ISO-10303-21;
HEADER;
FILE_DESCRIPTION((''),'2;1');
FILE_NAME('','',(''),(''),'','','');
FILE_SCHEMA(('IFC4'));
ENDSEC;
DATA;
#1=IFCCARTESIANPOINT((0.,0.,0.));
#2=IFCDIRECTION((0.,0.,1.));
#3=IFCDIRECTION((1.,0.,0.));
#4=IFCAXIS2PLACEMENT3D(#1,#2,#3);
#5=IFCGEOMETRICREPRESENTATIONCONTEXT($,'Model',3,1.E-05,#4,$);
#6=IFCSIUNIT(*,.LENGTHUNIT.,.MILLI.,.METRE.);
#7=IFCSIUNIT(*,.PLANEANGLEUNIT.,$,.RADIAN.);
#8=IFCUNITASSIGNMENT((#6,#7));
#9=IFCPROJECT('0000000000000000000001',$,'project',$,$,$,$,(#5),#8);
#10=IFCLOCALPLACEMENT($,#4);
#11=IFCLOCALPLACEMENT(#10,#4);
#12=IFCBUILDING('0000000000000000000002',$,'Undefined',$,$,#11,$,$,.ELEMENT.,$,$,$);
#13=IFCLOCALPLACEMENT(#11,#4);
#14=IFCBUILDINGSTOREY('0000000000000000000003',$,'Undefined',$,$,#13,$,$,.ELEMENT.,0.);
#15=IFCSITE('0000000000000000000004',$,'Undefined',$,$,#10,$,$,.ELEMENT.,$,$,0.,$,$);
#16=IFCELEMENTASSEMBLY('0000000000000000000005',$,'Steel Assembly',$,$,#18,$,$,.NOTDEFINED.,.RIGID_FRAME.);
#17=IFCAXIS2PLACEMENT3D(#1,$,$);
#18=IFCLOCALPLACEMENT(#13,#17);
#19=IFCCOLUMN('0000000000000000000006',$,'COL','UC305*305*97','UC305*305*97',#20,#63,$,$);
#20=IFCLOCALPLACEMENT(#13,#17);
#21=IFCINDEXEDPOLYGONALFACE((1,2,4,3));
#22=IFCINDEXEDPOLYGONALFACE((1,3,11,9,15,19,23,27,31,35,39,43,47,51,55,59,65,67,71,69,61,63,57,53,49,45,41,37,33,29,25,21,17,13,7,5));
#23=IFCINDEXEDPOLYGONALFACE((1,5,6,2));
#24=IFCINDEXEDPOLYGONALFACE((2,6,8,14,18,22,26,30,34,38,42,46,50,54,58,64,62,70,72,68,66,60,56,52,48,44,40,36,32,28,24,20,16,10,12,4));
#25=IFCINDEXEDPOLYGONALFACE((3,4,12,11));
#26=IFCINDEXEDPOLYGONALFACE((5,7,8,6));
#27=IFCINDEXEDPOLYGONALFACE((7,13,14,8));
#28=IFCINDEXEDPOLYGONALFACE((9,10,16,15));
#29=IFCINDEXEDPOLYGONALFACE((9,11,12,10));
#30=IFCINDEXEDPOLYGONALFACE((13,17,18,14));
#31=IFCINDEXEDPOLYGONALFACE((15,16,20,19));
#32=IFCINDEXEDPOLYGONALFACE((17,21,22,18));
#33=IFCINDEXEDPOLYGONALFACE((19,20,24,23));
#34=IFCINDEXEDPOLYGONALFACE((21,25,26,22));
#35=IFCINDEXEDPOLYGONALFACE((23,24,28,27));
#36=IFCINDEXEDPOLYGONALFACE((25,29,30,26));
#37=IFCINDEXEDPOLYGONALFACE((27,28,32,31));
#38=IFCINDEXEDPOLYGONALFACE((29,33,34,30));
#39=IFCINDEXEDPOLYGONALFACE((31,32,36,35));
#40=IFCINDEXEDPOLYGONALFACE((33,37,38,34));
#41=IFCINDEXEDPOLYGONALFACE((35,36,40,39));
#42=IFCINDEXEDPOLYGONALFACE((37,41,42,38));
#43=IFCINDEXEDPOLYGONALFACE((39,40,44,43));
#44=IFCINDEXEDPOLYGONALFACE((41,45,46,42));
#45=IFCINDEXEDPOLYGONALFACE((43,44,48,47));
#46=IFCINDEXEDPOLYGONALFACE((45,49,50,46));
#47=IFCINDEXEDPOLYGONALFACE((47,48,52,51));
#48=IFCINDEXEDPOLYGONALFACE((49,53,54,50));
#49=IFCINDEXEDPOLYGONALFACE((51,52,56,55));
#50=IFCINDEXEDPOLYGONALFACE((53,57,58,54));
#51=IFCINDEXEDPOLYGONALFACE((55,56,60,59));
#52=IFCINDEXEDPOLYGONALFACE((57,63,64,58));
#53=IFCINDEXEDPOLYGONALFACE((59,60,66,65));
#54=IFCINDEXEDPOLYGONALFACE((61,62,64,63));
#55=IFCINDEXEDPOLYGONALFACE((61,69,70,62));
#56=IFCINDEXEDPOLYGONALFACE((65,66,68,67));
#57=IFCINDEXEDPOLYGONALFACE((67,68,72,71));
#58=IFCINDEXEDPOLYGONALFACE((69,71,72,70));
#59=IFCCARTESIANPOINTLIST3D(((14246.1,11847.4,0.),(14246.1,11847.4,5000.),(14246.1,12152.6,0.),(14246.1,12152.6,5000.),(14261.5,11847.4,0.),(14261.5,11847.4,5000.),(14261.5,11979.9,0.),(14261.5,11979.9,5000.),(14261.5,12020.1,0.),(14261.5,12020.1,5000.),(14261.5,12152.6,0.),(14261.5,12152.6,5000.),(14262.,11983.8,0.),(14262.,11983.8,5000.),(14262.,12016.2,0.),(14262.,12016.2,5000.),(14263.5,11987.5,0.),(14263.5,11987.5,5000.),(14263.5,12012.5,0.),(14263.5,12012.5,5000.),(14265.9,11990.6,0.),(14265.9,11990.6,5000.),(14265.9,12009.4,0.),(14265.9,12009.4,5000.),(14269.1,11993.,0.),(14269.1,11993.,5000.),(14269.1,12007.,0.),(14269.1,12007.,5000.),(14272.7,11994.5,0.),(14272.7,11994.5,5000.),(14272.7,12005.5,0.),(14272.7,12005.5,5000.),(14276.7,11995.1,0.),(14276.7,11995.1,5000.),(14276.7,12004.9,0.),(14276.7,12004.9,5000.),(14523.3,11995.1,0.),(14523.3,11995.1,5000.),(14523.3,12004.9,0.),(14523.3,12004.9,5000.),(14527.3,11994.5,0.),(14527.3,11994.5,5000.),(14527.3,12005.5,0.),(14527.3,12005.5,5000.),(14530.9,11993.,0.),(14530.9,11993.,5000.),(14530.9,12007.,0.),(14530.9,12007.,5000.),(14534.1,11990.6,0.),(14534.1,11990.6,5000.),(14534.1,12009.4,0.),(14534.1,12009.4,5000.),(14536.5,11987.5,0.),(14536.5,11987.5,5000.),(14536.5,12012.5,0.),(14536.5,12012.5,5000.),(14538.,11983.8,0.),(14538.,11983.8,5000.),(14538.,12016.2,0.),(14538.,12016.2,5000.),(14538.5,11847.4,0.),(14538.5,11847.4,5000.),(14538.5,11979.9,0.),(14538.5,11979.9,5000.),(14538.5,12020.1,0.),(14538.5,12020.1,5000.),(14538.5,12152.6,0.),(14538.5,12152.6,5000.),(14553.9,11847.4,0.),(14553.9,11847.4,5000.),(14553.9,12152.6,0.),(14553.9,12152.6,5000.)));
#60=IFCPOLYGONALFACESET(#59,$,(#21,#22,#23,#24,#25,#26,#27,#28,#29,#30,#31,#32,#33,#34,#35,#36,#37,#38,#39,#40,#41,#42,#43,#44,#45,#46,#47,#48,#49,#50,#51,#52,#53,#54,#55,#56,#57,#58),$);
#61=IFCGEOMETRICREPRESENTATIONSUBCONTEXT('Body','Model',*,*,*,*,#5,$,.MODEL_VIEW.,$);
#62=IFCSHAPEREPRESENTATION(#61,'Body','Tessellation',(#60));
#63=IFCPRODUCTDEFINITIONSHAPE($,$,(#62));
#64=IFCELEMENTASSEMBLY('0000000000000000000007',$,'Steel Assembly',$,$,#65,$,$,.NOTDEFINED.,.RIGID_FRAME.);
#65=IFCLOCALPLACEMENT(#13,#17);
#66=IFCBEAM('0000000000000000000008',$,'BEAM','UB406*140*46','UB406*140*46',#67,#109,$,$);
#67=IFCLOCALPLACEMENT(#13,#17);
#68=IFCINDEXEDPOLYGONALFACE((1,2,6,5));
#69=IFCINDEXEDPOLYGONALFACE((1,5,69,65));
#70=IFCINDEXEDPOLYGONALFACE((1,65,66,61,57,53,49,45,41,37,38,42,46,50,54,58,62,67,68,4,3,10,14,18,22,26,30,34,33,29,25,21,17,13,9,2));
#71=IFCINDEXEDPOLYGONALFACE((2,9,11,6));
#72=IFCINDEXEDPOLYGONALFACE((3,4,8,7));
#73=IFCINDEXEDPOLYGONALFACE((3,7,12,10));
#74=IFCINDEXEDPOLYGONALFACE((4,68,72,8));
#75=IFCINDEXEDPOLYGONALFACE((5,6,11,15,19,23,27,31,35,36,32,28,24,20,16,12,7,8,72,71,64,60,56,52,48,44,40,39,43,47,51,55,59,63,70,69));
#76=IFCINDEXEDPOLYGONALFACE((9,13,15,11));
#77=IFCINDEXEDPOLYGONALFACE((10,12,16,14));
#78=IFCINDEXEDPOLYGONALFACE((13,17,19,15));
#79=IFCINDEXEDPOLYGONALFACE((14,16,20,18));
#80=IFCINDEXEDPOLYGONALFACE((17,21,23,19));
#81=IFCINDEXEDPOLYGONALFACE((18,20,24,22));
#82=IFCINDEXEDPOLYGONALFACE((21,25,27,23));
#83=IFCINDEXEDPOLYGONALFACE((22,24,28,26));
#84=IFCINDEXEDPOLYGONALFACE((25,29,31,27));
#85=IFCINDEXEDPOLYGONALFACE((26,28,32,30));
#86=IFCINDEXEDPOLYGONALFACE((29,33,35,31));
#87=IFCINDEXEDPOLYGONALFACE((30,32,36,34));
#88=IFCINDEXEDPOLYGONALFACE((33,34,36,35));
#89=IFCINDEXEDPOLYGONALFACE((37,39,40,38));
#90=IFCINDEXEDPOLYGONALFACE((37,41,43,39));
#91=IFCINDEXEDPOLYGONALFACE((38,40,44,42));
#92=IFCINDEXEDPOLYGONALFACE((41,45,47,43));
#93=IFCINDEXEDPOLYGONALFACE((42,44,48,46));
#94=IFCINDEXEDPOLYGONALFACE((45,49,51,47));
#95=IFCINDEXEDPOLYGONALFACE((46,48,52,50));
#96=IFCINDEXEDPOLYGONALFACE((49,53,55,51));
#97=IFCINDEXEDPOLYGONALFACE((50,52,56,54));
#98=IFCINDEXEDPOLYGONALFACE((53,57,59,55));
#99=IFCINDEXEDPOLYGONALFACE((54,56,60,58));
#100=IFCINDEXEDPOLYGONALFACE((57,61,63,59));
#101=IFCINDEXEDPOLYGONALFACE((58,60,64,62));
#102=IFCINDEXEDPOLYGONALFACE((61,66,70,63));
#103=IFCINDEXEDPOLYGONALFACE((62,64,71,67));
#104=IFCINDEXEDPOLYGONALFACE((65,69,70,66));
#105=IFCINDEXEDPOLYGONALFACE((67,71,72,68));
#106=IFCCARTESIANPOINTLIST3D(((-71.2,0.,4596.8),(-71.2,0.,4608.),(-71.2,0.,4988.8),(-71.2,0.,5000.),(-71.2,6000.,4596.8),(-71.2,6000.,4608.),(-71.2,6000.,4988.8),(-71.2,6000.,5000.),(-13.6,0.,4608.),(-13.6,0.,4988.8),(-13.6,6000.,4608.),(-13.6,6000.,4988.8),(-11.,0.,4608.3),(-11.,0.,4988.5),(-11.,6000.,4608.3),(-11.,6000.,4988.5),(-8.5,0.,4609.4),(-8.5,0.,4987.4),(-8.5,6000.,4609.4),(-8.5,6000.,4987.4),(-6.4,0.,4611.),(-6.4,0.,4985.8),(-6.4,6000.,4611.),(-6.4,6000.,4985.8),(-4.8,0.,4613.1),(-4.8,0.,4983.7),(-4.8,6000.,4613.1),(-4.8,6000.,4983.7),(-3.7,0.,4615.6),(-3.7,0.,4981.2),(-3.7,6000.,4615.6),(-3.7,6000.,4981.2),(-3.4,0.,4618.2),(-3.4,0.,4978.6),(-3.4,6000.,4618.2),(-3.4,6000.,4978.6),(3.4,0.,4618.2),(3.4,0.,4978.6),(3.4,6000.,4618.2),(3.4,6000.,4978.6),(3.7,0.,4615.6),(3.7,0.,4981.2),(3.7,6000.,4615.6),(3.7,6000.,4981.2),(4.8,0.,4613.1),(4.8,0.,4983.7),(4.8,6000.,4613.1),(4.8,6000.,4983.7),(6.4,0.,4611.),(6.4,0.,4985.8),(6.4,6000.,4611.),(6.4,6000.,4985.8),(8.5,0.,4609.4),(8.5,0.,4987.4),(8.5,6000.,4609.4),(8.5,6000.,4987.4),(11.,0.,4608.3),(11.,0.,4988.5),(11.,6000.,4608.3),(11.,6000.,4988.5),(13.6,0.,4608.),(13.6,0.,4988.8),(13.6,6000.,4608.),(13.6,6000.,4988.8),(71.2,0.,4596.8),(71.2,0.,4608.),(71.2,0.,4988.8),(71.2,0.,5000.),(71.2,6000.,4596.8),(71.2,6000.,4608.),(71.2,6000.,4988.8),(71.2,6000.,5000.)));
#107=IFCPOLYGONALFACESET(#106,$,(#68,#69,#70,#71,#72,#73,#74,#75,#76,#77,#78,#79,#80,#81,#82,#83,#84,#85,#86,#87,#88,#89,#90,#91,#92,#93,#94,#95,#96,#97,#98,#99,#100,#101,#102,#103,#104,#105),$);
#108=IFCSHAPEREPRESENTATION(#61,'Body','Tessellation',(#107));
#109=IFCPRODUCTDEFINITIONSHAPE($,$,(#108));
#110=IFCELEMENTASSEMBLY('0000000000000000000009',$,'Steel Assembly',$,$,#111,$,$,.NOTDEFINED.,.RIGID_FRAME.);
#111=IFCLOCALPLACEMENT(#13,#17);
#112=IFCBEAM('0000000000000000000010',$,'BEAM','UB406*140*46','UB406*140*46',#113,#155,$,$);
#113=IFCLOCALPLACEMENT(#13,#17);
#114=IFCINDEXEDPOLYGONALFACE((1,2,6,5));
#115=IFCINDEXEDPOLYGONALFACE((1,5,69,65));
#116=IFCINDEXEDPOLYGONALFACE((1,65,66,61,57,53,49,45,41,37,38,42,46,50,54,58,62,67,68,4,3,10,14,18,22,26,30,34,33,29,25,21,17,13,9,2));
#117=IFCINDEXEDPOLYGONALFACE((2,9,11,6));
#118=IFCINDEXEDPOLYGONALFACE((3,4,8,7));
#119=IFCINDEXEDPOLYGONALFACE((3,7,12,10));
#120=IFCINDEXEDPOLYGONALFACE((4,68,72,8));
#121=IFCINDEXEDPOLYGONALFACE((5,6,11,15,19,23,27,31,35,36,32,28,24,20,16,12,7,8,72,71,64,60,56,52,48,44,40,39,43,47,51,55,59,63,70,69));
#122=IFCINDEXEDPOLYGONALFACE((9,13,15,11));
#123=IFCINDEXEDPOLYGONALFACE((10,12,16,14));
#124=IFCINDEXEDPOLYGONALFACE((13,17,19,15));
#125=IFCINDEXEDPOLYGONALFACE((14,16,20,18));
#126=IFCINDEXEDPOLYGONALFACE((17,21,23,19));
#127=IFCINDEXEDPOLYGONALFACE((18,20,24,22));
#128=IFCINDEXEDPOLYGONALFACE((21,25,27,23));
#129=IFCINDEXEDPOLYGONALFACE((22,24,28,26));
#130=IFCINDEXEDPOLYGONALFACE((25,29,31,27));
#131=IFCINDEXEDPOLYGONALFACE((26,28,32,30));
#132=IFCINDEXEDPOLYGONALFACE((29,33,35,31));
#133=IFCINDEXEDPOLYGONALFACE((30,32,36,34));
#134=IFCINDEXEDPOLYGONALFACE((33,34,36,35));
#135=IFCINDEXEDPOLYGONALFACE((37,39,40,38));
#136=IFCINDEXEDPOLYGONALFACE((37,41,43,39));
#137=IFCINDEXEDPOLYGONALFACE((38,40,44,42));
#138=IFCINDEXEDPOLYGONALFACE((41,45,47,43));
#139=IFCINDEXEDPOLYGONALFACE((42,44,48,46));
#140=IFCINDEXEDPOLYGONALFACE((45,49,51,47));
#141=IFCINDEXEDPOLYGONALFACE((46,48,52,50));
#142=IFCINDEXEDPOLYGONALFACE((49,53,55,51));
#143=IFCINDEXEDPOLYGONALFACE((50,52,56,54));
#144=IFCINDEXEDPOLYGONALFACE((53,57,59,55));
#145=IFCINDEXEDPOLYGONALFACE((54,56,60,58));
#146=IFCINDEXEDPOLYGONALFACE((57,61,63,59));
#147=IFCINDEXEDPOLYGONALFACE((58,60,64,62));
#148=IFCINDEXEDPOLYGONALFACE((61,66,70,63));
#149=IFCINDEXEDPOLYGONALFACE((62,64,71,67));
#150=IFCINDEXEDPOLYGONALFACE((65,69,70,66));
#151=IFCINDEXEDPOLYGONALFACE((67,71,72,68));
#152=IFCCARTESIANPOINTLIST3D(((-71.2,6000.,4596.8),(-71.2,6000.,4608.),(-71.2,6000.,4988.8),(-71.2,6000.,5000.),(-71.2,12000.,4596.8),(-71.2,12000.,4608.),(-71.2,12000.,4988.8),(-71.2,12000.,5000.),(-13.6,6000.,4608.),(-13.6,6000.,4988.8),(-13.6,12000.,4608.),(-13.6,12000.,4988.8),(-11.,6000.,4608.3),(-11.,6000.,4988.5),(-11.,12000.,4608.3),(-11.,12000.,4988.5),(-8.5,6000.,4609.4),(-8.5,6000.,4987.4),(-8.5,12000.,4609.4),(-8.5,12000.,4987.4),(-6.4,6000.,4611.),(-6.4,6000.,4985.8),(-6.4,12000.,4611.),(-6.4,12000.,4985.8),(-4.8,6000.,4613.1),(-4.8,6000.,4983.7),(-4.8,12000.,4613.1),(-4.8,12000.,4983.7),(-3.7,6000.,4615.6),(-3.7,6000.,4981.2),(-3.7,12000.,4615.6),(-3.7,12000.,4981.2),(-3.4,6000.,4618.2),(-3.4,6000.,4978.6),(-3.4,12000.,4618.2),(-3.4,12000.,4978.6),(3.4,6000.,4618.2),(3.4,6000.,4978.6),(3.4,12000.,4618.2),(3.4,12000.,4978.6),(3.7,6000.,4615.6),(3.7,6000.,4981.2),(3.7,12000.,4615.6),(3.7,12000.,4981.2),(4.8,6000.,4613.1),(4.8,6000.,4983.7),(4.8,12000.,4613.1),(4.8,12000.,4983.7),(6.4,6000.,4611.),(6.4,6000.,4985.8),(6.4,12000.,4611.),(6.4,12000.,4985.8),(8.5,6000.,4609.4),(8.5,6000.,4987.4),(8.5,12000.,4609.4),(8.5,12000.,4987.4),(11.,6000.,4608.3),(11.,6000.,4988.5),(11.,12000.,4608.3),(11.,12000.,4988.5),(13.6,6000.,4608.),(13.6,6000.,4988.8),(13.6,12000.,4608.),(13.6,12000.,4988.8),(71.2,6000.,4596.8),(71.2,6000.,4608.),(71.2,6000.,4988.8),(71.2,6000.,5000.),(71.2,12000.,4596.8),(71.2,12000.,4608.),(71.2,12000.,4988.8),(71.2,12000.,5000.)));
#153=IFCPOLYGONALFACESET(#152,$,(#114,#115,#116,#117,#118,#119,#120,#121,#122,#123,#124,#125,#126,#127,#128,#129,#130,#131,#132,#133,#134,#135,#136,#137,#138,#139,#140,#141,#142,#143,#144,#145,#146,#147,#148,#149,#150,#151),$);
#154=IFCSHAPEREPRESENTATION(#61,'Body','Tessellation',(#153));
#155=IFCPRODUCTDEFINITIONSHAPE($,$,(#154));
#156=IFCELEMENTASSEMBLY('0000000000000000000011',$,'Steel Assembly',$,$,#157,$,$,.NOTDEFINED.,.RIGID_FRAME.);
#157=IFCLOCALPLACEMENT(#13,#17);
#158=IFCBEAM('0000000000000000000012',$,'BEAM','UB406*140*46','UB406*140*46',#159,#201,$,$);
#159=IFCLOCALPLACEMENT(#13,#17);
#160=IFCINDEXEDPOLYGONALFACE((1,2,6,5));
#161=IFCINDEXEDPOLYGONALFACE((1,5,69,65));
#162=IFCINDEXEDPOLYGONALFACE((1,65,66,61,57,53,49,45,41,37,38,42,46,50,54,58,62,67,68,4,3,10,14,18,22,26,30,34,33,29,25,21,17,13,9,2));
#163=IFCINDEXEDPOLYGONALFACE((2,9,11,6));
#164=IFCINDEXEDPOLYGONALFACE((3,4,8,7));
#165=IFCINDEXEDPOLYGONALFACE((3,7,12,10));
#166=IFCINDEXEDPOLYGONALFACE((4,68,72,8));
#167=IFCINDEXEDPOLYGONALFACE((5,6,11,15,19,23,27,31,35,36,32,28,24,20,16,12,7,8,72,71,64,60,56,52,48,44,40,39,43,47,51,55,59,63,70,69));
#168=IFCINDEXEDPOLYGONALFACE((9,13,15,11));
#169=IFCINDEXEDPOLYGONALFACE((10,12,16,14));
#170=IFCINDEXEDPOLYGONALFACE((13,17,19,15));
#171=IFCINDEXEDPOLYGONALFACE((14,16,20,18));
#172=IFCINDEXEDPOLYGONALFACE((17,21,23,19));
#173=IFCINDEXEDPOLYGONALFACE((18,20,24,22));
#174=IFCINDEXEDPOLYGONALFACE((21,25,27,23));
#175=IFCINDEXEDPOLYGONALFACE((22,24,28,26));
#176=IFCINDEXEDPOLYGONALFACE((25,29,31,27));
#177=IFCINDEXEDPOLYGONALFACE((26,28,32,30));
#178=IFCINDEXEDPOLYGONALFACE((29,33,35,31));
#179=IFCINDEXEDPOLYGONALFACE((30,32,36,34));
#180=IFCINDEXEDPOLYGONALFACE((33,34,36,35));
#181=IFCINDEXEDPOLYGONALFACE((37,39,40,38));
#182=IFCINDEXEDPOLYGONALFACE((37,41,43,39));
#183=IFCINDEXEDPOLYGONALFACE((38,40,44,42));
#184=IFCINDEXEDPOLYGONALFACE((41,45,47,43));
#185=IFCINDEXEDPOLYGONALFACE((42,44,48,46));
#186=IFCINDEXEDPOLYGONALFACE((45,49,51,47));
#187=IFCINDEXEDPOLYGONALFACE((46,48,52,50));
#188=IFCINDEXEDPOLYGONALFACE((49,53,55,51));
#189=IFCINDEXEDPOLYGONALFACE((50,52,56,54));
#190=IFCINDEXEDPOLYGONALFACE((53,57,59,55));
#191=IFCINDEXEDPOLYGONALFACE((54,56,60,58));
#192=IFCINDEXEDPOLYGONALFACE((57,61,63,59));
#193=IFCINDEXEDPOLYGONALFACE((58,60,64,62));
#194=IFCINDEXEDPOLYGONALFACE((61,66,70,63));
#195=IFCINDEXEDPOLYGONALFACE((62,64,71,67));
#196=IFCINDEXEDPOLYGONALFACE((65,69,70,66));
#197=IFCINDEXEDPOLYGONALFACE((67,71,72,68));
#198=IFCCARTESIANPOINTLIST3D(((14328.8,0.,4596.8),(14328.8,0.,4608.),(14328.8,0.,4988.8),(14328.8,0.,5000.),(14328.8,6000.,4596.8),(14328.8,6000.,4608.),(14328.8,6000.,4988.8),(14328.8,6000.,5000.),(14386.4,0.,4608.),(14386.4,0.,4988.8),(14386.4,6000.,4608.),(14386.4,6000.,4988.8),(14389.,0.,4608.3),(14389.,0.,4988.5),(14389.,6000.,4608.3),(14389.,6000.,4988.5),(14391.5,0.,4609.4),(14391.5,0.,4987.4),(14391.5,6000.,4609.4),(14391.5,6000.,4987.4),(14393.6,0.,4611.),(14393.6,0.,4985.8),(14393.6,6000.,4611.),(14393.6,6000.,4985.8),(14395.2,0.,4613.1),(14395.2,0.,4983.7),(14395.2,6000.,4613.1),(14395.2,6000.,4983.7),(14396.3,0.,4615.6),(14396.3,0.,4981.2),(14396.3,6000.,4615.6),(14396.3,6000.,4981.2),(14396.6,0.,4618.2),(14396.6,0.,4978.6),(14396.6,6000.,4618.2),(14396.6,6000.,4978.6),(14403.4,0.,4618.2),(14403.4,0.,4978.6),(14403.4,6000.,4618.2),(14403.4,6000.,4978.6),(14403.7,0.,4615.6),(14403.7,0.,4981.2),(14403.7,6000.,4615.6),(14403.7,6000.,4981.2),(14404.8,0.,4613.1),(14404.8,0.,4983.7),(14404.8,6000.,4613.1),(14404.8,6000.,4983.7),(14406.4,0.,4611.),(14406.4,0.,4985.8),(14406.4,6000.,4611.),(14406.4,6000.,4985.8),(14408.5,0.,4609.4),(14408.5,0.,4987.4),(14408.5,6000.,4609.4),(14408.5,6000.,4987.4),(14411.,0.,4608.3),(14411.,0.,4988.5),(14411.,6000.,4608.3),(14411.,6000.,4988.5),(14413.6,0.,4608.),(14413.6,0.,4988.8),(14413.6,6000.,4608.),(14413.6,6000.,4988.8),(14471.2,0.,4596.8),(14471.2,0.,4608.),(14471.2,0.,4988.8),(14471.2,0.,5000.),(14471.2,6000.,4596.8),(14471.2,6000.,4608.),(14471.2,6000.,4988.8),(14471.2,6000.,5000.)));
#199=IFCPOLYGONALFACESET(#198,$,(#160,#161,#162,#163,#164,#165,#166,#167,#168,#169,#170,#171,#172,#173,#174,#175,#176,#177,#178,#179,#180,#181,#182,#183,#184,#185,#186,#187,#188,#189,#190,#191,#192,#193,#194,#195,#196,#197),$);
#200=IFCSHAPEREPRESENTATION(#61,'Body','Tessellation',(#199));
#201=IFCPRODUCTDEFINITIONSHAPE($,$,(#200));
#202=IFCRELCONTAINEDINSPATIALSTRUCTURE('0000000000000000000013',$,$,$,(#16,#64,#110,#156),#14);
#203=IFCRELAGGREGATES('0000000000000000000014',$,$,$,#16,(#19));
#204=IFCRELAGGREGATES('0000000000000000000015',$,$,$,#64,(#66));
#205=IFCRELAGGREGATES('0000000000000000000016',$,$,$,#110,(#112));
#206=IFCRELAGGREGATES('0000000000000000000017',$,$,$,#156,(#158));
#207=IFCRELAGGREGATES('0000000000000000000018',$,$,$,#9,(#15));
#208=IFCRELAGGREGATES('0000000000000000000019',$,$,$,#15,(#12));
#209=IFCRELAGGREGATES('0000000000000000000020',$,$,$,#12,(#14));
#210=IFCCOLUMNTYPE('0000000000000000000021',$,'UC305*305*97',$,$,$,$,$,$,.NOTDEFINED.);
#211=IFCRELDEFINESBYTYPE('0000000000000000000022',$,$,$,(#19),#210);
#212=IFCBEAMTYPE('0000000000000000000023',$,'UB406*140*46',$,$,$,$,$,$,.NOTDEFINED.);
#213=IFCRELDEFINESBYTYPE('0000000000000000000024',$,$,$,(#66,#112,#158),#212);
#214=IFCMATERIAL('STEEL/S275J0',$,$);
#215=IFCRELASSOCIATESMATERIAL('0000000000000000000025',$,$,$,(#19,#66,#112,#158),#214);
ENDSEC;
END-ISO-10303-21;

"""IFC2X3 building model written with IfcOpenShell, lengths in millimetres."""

from ifc_helpers import new_model, si_unit, frame, origin_with_axes, origin_2d_with_axis, place, context, subcontext, project, spatial, i_section, extrude, material, type_object, element, aggregate, save


model = new_model("IFC2X3")

# Units and contexts
model_context = context("Model", 3, precision=1e-05, world=origin_with_axes())
body_context = subcontext(model_context, "Body", "Model", "MODEL_VIEW")
ifc_project = project(units=[si_unit("LENGTHUNIT", "METRE", prefix="MILLI"), si_unit("PLANEANGLEUNIT", "RADIAN")], contexts=[model_context])

# Site, building, storey
site_placement = place(None, origin_with_axes())
site = spatial("IfcSite", under=ifc_project, at=site_placement, Name="Undefined", CompositionType="ELEMENT", RefElevation=0.0)
building_placement = place(site_placement, origin_with_axes())
building = spatial("IfcBuilding", under=site, at=building_placement, Name="Undefined", CompositionType="ELEMENT")
storey_placement = place(building_placement, origin_with_axes())
storey = spatial("IfcBuildingStorey", under=building, at=storey_placement, Name="Undefined", CompositionType="ELEMENT", Elevation=0.0)

# Element assembly, column
ifc_material = material(Name="STEEL/S275J0")
column_type_1 = type_object("IfcColumnType", Name="UC305*305*97", PredefinedType="NOTDEFINED")
assembly_1_placement = place(storey_placement, origin_with_axes())
assembly_1 = element("IfcElementAssembly", 1, at=assembly_1_placement, inside=storey, Name="Steel Assembly", AssemblyPlace="NOTDEFINED", PredefinedType="RIGID_FRAME")
column_1_placement = place(assembly_1_placement, frame((14400.0, 12000.0, 0.0), z_axis=(0.0, 0.0, 1.0), x_axis=(1.0, 0.0, 0.0)))
column_1 = element("IfcColumn", 2, at=column_1_placement, type_object=column_type_1, material=ifc_material, Name="COL", Description="UC305*305*97", ObjectType="UC305*305*97", context=body_context, shape_type="SweptSolid", body=[
    extrude(i_section(OverallWidth=305.3, OverallDepth=307.9, WebThickness=9.9, FlangeThickness=15.4, FilletRadius=15.2, at=origin_2d_with_axis()), frame((0.0, 0.0, 5000.0), z_axis=(0.0, 0.0, -1.0), x_axis=(0.0, -1.0, 0.0)), (0.0, 0.0, 1.0), 5000.0),
])
aggregate(assembly_1, [column_1])

# Element assemblies, beams
assembly_2_placement = place(storey_placement, origin_with_axes())
assembly_2 = element("IfcElementAssembly", 3, at=assembly_2_placement, inside=storey, Name="Steel Assembly", AssemblyPlace="NOTDEFINED", PredefinedType="RIGID_FRAME")
beam_type_1 = type_object("IfcBeamType", Name="UB406*140*46", PredefinedType="NOTDEFINED")
beam_1_placement = place(assembly_2_placement, frame((0.0, 0.0, 4798.4), z_axis=(0.0, 0.0, 1.0), x_axis=(0.0, 1.0, 0.0)))
beam_1 = element("IfcBeam", 4, at=beam_1_placement, type_object=beam_type_1, material=ifc_material, Name="BEAM", Description="UB406*140*46", ObjectType="UB406*140*46", context=body_context, shape_type="SweptSolid", body=[
    extrude(i_section(OverallWidth=142.4, OverallDepth=403.2, WebThickness=6.8, FlangeThickness=11.2, FilletRadius=10.2, at=origin_2d_with_axis()), frame((6000.0, 0.0, 0.0), z_axis=(-1.0, 0.0, 0.0), x_axis=(0.0, -1.0, 0.0)), (0.0, 0.0, 1.0), 6000.0),
])
aggregate(assembly_2, [beam_1])
assembly_3_placement = place(storey_placement, origin_with_axes())
assembly_3 = element("IfcElementAssembly", 5, at=assembly_3_placement, inside=storey, Name="Steel Assembly", AssemblyPlace="NOTDEFINED", PredefinedType="RIGID_FRAME")
beam_2_placement = place(assembly_3_placement, frame((0.0, 6000.0, 4798.4), z_axis=(0.0, 0.0, 1.0), x_axis=(0.0, 1.0, 0.0)))
beam_2 = element("IfcBeam", 6, at=beam_2_placement, type_object=beam_type_1, material=ifc_material, Name="BEAM", Description="UB406*140*46", ObjectType="UB406*140*46", context=body_context, shape_type="SweptSolid", body=[
    extrude(i_section(OverallWidth=142.4, OverallDepth=403.2, WebThickness=6.8, FlangeThickness=11.2, FilletRadius=10.2, at=origin_2d_with_axis()), frame((6000.0, 0.0, 0.0), z_axis=(-1.0, 0.0, 0.0), x_axis=(0.0, -1.0, 0.0)), (0.0, 0.0, 1.0), 6000.0),
])
aggregate(assembly_3, [beam_2])
assembly_4_placement = place(storey_placement, origin_with_axes())
assembly_4 = element("IfcElementAssembly", 7, at=assembly_4_placement, inside=storey, Name="Steel Assembly", AssemblyPlace="NOTDEFINED", PredefinedType="RIGID_FRAME")
beam_3_placement = place(assembly_4_placement, frame((14400.0, 0.0, 4798.4), z_axis=(0.0, 0.0, 1.0), x_axis=(0.0, 1.0, 0.0)))
beam_3 = element("IfcBeam", 8, at=beam_3_placement, type_object=beam_type_1, material=ifc_material, Name="BEAM", Description="UB406*140*46", ObjectType="UB406*140*46", context=body_context, shape_type="SweptSolid", body=[
    extrude(i_section(OverallWidth=142.4, OverallDepth=403.2, WebThickness=6.8, FlangeThickness=11.2, FilletRadius=10.2, at=origin_2d_with_axis()), frame((6000.0, 0.0, 0.0), z_axis=(-1.0, 0.0, 0.0), x_axis=(0.0, -1.0, 0.0)), (0.0, 0.0, 1.0), 6000.0),
])
aggregate(assembly_4, [beam_3])

save(model, "model.ifc")
